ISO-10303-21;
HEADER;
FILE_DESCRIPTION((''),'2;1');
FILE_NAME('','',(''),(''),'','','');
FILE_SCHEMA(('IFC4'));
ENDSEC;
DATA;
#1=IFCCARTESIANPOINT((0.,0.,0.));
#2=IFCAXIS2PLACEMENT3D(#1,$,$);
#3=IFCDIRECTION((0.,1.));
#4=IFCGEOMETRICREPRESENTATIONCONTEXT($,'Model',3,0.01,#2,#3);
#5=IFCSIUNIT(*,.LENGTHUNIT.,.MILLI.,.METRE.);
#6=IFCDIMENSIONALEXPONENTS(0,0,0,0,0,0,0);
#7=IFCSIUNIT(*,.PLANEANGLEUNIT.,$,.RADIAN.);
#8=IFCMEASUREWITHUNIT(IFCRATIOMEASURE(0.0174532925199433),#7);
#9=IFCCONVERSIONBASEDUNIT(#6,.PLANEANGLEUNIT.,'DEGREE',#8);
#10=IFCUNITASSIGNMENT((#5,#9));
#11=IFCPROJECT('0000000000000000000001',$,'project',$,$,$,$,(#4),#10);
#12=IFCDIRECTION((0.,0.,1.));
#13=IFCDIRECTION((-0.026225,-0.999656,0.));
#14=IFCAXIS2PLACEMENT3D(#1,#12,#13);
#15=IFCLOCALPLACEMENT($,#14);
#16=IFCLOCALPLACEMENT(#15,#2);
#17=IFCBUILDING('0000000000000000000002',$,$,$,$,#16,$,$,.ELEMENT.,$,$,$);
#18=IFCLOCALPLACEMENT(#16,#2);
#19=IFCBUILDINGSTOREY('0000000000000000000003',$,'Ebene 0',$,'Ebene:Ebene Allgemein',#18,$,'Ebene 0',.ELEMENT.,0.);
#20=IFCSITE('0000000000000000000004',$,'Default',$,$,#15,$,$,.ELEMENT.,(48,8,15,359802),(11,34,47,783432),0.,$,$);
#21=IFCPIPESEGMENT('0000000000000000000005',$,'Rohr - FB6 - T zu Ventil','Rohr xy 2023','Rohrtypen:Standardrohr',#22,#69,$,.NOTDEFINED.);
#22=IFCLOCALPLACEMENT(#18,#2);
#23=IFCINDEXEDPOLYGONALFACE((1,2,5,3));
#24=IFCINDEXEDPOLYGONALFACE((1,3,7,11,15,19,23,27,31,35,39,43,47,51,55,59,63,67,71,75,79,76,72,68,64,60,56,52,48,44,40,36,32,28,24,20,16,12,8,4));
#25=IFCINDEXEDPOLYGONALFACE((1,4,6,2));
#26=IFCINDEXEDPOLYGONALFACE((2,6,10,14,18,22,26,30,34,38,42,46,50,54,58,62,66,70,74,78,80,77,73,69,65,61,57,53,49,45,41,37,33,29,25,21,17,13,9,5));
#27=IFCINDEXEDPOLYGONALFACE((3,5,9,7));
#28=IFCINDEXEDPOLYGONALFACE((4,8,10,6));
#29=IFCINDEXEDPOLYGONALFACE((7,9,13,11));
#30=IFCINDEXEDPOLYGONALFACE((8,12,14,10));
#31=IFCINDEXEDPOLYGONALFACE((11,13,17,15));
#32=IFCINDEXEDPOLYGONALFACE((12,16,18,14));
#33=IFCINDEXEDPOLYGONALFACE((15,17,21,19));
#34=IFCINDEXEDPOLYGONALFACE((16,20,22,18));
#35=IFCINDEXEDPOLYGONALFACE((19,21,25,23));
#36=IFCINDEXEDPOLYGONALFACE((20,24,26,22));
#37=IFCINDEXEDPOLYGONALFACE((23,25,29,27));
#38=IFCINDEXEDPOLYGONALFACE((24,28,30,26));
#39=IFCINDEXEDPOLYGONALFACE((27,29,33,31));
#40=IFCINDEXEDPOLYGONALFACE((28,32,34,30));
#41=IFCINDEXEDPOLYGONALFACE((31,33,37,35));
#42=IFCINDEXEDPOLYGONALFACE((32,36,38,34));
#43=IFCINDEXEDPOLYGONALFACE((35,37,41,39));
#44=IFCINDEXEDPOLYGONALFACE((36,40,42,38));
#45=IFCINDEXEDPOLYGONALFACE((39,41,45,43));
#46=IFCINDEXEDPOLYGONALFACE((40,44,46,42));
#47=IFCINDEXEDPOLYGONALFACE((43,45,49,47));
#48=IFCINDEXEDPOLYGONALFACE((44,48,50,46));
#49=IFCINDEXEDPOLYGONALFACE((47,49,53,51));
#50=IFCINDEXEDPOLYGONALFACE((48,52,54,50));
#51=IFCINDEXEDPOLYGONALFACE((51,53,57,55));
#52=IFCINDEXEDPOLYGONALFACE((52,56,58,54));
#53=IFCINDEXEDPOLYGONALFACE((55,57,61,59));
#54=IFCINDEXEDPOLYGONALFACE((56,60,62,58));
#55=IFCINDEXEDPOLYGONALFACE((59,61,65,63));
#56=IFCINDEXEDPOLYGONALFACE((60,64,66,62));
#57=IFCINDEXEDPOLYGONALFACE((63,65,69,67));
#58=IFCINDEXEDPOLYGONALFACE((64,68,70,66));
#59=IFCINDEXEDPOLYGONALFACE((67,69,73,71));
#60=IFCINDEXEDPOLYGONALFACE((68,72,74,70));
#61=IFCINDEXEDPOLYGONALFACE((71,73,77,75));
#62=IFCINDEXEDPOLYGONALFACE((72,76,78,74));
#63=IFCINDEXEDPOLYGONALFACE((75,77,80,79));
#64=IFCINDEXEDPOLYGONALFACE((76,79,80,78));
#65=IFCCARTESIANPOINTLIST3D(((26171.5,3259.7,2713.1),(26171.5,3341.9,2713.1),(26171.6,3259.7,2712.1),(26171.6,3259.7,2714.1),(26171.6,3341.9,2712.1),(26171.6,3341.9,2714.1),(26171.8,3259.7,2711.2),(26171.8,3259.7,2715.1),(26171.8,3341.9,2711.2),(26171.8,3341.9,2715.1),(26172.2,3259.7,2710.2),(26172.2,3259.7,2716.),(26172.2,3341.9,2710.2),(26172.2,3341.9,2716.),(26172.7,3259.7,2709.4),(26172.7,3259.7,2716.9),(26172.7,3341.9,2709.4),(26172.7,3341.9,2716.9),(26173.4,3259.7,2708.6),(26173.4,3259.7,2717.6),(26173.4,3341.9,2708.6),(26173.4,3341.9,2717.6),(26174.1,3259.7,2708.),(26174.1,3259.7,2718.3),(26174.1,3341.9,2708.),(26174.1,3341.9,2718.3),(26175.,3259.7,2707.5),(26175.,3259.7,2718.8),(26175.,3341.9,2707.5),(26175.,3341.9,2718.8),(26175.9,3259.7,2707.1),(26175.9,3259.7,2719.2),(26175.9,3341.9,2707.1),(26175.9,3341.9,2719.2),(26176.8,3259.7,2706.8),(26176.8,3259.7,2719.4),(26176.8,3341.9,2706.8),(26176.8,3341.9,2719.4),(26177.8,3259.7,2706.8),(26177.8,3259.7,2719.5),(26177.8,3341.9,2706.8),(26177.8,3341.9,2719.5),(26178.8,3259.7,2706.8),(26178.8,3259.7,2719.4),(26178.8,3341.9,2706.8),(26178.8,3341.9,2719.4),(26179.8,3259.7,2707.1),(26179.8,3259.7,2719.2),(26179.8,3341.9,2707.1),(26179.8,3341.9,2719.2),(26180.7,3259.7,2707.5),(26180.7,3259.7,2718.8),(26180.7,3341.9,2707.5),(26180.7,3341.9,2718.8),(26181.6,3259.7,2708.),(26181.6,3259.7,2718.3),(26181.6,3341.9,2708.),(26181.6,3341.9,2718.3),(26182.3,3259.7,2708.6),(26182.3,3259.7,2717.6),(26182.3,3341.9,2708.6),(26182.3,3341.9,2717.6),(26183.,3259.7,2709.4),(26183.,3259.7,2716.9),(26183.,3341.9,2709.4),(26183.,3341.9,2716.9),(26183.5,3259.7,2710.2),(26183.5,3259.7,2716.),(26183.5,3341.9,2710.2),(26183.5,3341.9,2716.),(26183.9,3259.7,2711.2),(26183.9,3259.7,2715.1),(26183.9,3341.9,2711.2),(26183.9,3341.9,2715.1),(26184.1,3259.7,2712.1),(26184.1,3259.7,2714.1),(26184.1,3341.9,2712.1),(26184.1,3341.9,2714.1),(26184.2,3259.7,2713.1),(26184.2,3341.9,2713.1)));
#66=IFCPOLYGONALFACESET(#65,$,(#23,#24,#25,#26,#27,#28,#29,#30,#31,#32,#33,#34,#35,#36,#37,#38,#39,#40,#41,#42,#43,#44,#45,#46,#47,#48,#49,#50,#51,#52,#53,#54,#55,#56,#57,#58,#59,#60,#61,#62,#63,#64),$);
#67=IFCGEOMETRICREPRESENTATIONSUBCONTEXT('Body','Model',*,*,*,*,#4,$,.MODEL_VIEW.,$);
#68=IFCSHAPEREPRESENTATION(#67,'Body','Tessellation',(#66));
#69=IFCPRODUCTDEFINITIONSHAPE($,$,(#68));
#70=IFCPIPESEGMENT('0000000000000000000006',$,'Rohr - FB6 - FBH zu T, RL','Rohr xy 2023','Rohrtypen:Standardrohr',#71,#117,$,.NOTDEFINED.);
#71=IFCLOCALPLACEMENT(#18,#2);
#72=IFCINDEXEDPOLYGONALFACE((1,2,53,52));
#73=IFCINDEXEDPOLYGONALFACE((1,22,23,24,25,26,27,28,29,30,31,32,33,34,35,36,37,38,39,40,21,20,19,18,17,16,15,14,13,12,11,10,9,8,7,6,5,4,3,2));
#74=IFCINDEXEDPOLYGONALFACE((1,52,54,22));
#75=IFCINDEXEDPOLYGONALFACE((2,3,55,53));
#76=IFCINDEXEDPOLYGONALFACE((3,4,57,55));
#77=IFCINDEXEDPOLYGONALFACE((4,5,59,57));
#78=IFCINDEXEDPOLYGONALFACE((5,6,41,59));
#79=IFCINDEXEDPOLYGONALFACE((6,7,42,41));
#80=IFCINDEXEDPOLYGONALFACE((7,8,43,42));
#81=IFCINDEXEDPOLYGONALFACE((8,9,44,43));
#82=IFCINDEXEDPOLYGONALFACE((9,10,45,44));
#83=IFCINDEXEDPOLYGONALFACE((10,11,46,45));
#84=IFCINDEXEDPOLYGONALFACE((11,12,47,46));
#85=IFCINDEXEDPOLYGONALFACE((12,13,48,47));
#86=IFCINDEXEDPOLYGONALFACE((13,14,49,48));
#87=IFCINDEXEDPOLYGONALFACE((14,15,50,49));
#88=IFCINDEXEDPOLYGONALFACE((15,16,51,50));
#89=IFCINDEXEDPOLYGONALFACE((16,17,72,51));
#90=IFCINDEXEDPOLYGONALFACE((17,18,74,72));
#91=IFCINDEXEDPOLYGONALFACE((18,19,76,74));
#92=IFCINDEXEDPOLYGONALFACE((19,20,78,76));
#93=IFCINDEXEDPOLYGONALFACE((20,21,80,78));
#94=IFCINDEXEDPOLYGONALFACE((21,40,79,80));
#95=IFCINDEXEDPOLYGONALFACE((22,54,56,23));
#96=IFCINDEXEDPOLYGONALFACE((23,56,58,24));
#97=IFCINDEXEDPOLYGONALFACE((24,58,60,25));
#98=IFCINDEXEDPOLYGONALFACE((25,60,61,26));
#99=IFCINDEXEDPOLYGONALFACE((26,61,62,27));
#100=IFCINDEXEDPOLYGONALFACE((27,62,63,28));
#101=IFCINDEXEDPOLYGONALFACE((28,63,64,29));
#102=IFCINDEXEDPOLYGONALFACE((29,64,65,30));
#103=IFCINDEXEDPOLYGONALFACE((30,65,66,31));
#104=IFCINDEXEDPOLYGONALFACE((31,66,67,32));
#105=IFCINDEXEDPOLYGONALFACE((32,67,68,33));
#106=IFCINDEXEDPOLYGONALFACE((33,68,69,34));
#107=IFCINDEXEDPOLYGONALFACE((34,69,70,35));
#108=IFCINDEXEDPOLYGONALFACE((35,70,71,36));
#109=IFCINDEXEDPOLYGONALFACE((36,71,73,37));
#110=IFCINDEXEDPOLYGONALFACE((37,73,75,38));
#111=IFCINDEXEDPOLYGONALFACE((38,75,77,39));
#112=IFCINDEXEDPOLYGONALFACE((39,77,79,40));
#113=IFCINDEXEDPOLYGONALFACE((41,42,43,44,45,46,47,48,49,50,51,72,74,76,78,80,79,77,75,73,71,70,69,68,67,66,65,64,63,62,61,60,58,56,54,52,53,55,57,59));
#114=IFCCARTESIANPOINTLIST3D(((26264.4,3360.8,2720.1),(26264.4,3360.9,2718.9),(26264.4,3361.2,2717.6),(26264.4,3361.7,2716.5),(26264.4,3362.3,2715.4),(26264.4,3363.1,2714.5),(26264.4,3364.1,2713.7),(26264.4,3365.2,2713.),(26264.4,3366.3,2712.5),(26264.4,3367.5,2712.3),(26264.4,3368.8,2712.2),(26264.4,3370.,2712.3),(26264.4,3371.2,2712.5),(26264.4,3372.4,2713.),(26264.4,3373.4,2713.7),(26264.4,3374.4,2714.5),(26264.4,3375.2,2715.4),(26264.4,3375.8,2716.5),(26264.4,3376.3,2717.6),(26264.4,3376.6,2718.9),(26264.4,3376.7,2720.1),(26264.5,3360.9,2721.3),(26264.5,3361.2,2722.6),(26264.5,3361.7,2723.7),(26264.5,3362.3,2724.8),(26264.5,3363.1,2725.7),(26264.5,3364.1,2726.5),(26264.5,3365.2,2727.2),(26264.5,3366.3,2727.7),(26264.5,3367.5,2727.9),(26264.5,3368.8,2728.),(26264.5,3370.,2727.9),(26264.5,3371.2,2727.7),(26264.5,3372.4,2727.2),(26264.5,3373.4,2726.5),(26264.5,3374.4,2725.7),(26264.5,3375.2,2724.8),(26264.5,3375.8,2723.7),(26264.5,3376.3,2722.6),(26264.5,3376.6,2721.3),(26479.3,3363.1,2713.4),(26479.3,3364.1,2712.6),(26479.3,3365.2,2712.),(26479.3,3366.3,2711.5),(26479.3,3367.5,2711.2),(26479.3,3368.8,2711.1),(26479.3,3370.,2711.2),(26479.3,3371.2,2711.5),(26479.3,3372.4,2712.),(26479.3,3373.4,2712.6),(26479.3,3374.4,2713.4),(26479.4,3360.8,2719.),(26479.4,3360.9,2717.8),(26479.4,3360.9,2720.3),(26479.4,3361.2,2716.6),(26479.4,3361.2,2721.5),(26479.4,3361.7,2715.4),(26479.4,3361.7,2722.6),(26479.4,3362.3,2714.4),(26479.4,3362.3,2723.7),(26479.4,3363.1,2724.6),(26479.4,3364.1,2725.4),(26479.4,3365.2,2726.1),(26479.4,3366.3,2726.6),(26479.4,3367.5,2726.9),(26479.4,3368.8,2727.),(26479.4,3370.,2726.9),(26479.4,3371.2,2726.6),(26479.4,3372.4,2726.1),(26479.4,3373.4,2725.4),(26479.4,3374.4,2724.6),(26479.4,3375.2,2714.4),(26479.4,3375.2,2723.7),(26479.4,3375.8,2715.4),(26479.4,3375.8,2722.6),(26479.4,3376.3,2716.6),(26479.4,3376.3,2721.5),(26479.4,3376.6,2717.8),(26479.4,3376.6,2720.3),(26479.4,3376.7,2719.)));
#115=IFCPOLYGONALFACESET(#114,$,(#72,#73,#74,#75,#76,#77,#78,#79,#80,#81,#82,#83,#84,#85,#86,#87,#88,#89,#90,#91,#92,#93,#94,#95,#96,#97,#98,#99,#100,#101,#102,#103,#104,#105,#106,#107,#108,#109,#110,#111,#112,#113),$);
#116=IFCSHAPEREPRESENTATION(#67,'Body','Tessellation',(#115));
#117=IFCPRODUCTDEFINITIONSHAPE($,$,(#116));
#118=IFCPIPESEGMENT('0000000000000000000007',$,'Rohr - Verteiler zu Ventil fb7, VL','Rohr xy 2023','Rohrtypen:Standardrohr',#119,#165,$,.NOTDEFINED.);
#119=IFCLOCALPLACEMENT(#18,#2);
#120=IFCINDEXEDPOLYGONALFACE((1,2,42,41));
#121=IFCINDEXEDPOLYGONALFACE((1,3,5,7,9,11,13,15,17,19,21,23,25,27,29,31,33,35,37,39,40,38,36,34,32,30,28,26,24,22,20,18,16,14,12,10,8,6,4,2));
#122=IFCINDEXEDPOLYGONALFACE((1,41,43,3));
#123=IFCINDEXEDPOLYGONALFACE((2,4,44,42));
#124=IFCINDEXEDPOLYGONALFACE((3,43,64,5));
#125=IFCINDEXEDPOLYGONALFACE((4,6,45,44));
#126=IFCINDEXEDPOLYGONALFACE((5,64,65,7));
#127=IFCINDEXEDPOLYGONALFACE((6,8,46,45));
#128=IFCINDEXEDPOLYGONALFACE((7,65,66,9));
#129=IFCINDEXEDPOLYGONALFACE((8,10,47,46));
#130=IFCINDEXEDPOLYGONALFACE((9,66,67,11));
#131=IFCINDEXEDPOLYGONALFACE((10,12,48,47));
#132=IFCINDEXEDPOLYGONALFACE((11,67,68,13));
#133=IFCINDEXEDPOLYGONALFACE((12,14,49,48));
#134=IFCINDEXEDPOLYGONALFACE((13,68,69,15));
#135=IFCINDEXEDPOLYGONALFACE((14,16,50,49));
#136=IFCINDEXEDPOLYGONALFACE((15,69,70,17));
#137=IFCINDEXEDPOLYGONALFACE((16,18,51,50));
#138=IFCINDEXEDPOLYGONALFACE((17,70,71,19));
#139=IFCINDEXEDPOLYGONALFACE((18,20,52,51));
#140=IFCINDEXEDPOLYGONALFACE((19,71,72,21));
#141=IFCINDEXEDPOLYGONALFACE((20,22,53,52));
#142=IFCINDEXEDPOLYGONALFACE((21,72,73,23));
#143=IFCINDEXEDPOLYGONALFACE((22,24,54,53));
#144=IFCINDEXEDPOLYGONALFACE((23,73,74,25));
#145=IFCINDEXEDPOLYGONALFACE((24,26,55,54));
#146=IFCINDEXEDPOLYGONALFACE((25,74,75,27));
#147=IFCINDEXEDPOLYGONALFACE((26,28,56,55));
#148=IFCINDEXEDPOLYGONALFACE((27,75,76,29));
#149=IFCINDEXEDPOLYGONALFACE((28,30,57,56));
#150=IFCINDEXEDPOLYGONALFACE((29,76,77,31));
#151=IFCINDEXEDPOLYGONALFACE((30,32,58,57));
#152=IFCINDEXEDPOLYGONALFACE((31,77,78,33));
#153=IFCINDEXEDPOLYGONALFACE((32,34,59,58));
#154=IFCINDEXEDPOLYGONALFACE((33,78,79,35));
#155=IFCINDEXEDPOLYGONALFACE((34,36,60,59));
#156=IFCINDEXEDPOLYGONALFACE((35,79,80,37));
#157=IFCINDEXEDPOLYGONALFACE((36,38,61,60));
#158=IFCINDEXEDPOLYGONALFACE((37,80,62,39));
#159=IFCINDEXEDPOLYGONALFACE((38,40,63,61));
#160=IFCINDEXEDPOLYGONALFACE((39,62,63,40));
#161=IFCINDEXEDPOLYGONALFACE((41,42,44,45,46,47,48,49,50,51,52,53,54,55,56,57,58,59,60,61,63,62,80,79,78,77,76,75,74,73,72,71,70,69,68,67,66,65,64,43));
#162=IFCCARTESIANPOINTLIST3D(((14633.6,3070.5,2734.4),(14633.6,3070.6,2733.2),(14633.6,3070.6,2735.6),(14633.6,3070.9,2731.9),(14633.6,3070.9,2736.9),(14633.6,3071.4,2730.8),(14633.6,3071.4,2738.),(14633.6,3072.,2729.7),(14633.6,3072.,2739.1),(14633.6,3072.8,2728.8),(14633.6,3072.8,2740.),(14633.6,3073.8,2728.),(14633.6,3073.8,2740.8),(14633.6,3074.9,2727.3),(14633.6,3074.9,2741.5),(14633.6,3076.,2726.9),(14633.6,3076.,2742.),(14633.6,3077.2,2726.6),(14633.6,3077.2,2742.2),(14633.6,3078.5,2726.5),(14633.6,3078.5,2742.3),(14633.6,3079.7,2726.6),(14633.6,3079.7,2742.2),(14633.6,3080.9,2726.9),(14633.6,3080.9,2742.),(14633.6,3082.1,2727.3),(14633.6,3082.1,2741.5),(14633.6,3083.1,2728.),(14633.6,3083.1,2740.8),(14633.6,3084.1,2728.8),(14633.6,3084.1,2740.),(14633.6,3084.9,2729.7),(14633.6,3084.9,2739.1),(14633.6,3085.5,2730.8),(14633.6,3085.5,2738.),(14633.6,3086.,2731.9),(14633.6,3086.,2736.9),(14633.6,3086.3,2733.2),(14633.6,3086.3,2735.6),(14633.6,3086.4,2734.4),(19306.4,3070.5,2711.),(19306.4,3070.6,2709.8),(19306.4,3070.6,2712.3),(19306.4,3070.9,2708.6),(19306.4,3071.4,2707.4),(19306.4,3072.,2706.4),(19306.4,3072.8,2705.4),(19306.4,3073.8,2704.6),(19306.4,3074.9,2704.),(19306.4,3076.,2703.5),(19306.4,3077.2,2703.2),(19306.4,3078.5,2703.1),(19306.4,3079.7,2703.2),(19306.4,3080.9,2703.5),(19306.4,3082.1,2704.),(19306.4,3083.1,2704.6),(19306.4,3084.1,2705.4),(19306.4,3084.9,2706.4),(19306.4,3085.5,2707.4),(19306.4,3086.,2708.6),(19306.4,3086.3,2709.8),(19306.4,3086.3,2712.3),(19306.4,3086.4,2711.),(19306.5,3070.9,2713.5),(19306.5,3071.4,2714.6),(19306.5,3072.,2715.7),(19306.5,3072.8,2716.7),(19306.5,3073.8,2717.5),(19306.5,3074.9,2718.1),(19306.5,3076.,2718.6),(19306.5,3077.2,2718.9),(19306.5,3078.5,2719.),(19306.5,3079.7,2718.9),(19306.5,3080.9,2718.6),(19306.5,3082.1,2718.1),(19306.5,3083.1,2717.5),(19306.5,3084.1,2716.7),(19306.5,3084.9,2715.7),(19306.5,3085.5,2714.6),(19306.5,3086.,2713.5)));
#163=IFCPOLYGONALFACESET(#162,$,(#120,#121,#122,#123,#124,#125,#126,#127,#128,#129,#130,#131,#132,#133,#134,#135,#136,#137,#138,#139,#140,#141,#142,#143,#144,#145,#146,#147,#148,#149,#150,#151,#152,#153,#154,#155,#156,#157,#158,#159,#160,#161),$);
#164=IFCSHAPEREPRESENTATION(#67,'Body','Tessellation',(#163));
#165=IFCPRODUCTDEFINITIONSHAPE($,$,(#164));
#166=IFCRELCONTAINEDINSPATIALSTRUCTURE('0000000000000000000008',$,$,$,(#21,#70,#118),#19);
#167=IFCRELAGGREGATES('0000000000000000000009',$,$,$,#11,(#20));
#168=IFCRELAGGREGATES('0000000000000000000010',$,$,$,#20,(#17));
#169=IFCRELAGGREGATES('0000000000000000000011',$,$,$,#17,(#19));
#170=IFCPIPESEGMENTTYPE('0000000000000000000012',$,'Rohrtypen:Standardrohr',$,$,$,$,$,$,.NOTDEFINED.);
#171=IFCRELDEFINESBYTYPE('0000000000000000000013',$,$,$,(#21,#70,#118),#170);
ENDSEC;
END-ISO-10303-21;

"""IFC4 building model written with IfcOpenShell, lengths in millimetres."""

from ifc_helpers import new_model, entity, si_unit, converted_unit, direction, frame, origin, place, context, subcontext, project, spatial, indexed_curve, outline, extrude, type_object, element, save


model = new_model("IFC4")

# Units and contexts
model_context = context("Model", 3, precision=0.01, world=origin(), true_north=direction((0.0, 1.0)))
body_context = subcontext(model_context, "Body", "Model", "MODEL_VIEW")
ifc_project = project(units=[si_unit("LENGTHUNIT", "METRE", prefix="MILLI"), converted_unit("PLANEANGLEUNIT", "DEGREE", entity("IfcRatioMeasure", 0.0174532925199433), si_unit("PLANEANGLEUNIT", "RADIAN"), dimensions=[0, 0, 0, 0, 0, 0, 0])], contexts=[model_context])

# Site, building, storey
site_placement = place(None, frame((0.0, 0.0, 0.0), z_axis=(0.0, 0.0, 1.0), x_axis=(-0.026225, -0.999656, 0.0)))
site = spatial("IfcSite", under=ifc_project, at=site_placement, Name="Default", CompositionType="ELEMENT", RefLatitude=(48, 8, 15, 359802), RefLongitude=(11, 34, 47, 783432), RefElevation=0.0)
building_placement = place(site_placement, origin())
building = spatial("IfcBuilding", under=site, at=building_placement, CompositionType="ELEMENT")
storey_placement = place(building_placement, origin())
storey = spatial("IfcBuildingStorey", under=building, at=storey_placement, Name="Ebene 0", ObjectType="Ebene:Ebene Allgemein", LongName="Ebene 0", CompositionType="ELEMENT", Elevation=0.0)

# Pipe segments
pipe_segment_type = type_object("IfcPipeSegmentType", Name="Rohrtypen:Standardrohr", PredefinedType="NOTDEFINED")
pipe_segment_1_placement = place(storey_placement, origin())
element("IfcPipeSegment", 1, at=pipe_segment_1_placement, inside=storey, type_object=pipe_segment_type, Name="Rohr - FB6 - T zu Ventil", Description="Rohr xy 2023", ObjectType="Rohrtypen:Standardrohr", PredefinedType="NOTDEFINED", context=body_context, shape_type="SweptSolid", body=[
    extrude(outline(indexed_curve([(6.3, 0.0), (6.3, 1.0), (6.0, 2.0), (5.7, 2.9), (5.1, 3.7), (4.5, 4.5), (3.7, 5.1), (2.9, 5.7), (2.0, 6.0), (1.0, 6.3), (0.0, 6.4), (-1.0, 6.3), (-2.0, 6.0), (-2.9, 5.7), (-3.7, 5.1), (-4.5, 4.5), (-5.1, 3.7), (-5.7, 2.9), (-6.0, 2.0), (-6.3, 1.0), (-6.3, 0.0), (-6.3, -1.0), (-6.0, -2.0), (-5.7, -2.9), (-5.1, -3.7), (-4.5, -4.5), (-3.7, -5.1), (-2.9, -5.7), (-2.0, -6.0), (-1.0, -6.3), (0.0, -6.4), (1.0, -6.3), (2.0, -6.0), (2.9, -5.7), (3.7, -5.1), (4.5, -4.5), (5.1, -3.7), (5.7, -2.9), (6.0, -2.0), (6.3, -1.0), (6.3, 0.0)], self_intersect=False)), frame((26177.8, 3259.7, 2713.1), z_axis=(0.0, 1.0, 0.0), x_axis=(-1.0, 0.0, 0.0)), (0.0, 0.0, 1.0), 82.2),
])
pipe_segment_2_placement = place(storey_placement, origin())
element("IfcPipeSegment", 2, at=pipe_segment_2_placement, inside=storey, type_object=pipe_segment_type, Name="Rohr - FB6 - FBH zu T, RL", Description="Rohr xy 2023", ObjectType="Rohrtypen:Standardrohr", PredefinedType="NOTDEFINED", context=body_context, shape_type="SweptSolid", body=[
    extrude(outline(indexed_curve([(7.9, 0.0), (7.8, 1.2), (7.6, 2.5), (7.1, 3.6), (6.4, 4.7), (5.6, 5.6), (4.7, 6.4), (3.6, 7.1), (2.5, 7.6), (1.2, 7.8), (0.0, 7.9), (-1.2, 7.8), (-2.5, 7.6), (-3.6, 7.1), (-4.7, 6.4), (-5.6, 5.6), (-6.4, 4.7), (-7.1, 3.6), (-7.6, 2.5), (-7.8, 1.2), (-7.9, 0.0), (-7.8, -1.2), (-7.6, -2.5), (-7.1, -3.6), (-6.4, -4.7), (-5.6, -5.6), (-4.7, -6.4), (-3.6, -7.1), (-2.5, -7.6), (-1.2, -7.8), (0.0, -7.9), (1.2, -7.8), (2.5, -7.6), (3.6, -7.1), (4.7, -6.4), (5.6, -5.6), (6.4, -4.7), (7.1, -3.6), (7.6, -2.5), (7.8, -1.2), (7.9, 0.0)], self_intersect=False)), frame((26479.4, 3368.8, 2719.0), z_axis=(-0.999988, 0.0, 0.005), x_axis=(0.0, 1.0, 0.0)), (0.0, 0.0, 1.0), 214.9),
])
pipe_segment_3_placement = place(storey_placement, origin())
element("IfcPipeSegment", 3, at=pipe_segment_3_placement, inside=storey, type_object=pipe_segment_type, Name="Rohr - Verteiler zu Ventil fb7, VL", Description="Rohr xy 2023", ObjectType="Rohrtypen:Standardrohr", PredefinedType="NOTDEFINED", context=body_context, shape_type="SweptSolid", body=[
    extrude(outline(indexed_curve([(7.9, 0.0), (7.8, 1.2), (7.6, 2.5), (7.1, 3.6), (6.4, 4.7), (5.6, 5.6), (4.7, 6.4), (3.6, 7.1), (2.5, 7.6), (1.2, 7.8), (0.0, 7.9), (-1.2, 7.8), (-2.5, 7.6), (-3.6, 7.1), (-4.7, 6.4), (-5.6, 5.6), (-6.4, 4.7), (-7.1, 3.6), (-7.6, 2.5), (-7.8, 1.2), (-7.9, 0.0), (-7.8, -1.2), (-7.6, -2.5), (-7.1, -3.6), (-6.4, -4.7), (-5.6, -5.6), (-4.7, -6.4), (-3.6, -7.1), (-2.5, -7.6), (-1.2, -7.8), (0.0, -7.9), (1.2, -7.8), (2.5, -7.6), (3.6, -7.1), (4.7, -6.4), (5.6, -5.6), (6.4, -4.7), (7.1, -3.6), (7.6, -2.5), (7.8, -1.2), (7.9, 0.0)], self_intersect=False)), frame((19306.4, 3078.5, 2711.0), z_axis=(-0.999988, 0.0, 0.005), x_axis=(0.0, 1.0, 0.0)), (0.0, 0.0, 1.0), 4672.9),
])

save(model, "model.ifc")
